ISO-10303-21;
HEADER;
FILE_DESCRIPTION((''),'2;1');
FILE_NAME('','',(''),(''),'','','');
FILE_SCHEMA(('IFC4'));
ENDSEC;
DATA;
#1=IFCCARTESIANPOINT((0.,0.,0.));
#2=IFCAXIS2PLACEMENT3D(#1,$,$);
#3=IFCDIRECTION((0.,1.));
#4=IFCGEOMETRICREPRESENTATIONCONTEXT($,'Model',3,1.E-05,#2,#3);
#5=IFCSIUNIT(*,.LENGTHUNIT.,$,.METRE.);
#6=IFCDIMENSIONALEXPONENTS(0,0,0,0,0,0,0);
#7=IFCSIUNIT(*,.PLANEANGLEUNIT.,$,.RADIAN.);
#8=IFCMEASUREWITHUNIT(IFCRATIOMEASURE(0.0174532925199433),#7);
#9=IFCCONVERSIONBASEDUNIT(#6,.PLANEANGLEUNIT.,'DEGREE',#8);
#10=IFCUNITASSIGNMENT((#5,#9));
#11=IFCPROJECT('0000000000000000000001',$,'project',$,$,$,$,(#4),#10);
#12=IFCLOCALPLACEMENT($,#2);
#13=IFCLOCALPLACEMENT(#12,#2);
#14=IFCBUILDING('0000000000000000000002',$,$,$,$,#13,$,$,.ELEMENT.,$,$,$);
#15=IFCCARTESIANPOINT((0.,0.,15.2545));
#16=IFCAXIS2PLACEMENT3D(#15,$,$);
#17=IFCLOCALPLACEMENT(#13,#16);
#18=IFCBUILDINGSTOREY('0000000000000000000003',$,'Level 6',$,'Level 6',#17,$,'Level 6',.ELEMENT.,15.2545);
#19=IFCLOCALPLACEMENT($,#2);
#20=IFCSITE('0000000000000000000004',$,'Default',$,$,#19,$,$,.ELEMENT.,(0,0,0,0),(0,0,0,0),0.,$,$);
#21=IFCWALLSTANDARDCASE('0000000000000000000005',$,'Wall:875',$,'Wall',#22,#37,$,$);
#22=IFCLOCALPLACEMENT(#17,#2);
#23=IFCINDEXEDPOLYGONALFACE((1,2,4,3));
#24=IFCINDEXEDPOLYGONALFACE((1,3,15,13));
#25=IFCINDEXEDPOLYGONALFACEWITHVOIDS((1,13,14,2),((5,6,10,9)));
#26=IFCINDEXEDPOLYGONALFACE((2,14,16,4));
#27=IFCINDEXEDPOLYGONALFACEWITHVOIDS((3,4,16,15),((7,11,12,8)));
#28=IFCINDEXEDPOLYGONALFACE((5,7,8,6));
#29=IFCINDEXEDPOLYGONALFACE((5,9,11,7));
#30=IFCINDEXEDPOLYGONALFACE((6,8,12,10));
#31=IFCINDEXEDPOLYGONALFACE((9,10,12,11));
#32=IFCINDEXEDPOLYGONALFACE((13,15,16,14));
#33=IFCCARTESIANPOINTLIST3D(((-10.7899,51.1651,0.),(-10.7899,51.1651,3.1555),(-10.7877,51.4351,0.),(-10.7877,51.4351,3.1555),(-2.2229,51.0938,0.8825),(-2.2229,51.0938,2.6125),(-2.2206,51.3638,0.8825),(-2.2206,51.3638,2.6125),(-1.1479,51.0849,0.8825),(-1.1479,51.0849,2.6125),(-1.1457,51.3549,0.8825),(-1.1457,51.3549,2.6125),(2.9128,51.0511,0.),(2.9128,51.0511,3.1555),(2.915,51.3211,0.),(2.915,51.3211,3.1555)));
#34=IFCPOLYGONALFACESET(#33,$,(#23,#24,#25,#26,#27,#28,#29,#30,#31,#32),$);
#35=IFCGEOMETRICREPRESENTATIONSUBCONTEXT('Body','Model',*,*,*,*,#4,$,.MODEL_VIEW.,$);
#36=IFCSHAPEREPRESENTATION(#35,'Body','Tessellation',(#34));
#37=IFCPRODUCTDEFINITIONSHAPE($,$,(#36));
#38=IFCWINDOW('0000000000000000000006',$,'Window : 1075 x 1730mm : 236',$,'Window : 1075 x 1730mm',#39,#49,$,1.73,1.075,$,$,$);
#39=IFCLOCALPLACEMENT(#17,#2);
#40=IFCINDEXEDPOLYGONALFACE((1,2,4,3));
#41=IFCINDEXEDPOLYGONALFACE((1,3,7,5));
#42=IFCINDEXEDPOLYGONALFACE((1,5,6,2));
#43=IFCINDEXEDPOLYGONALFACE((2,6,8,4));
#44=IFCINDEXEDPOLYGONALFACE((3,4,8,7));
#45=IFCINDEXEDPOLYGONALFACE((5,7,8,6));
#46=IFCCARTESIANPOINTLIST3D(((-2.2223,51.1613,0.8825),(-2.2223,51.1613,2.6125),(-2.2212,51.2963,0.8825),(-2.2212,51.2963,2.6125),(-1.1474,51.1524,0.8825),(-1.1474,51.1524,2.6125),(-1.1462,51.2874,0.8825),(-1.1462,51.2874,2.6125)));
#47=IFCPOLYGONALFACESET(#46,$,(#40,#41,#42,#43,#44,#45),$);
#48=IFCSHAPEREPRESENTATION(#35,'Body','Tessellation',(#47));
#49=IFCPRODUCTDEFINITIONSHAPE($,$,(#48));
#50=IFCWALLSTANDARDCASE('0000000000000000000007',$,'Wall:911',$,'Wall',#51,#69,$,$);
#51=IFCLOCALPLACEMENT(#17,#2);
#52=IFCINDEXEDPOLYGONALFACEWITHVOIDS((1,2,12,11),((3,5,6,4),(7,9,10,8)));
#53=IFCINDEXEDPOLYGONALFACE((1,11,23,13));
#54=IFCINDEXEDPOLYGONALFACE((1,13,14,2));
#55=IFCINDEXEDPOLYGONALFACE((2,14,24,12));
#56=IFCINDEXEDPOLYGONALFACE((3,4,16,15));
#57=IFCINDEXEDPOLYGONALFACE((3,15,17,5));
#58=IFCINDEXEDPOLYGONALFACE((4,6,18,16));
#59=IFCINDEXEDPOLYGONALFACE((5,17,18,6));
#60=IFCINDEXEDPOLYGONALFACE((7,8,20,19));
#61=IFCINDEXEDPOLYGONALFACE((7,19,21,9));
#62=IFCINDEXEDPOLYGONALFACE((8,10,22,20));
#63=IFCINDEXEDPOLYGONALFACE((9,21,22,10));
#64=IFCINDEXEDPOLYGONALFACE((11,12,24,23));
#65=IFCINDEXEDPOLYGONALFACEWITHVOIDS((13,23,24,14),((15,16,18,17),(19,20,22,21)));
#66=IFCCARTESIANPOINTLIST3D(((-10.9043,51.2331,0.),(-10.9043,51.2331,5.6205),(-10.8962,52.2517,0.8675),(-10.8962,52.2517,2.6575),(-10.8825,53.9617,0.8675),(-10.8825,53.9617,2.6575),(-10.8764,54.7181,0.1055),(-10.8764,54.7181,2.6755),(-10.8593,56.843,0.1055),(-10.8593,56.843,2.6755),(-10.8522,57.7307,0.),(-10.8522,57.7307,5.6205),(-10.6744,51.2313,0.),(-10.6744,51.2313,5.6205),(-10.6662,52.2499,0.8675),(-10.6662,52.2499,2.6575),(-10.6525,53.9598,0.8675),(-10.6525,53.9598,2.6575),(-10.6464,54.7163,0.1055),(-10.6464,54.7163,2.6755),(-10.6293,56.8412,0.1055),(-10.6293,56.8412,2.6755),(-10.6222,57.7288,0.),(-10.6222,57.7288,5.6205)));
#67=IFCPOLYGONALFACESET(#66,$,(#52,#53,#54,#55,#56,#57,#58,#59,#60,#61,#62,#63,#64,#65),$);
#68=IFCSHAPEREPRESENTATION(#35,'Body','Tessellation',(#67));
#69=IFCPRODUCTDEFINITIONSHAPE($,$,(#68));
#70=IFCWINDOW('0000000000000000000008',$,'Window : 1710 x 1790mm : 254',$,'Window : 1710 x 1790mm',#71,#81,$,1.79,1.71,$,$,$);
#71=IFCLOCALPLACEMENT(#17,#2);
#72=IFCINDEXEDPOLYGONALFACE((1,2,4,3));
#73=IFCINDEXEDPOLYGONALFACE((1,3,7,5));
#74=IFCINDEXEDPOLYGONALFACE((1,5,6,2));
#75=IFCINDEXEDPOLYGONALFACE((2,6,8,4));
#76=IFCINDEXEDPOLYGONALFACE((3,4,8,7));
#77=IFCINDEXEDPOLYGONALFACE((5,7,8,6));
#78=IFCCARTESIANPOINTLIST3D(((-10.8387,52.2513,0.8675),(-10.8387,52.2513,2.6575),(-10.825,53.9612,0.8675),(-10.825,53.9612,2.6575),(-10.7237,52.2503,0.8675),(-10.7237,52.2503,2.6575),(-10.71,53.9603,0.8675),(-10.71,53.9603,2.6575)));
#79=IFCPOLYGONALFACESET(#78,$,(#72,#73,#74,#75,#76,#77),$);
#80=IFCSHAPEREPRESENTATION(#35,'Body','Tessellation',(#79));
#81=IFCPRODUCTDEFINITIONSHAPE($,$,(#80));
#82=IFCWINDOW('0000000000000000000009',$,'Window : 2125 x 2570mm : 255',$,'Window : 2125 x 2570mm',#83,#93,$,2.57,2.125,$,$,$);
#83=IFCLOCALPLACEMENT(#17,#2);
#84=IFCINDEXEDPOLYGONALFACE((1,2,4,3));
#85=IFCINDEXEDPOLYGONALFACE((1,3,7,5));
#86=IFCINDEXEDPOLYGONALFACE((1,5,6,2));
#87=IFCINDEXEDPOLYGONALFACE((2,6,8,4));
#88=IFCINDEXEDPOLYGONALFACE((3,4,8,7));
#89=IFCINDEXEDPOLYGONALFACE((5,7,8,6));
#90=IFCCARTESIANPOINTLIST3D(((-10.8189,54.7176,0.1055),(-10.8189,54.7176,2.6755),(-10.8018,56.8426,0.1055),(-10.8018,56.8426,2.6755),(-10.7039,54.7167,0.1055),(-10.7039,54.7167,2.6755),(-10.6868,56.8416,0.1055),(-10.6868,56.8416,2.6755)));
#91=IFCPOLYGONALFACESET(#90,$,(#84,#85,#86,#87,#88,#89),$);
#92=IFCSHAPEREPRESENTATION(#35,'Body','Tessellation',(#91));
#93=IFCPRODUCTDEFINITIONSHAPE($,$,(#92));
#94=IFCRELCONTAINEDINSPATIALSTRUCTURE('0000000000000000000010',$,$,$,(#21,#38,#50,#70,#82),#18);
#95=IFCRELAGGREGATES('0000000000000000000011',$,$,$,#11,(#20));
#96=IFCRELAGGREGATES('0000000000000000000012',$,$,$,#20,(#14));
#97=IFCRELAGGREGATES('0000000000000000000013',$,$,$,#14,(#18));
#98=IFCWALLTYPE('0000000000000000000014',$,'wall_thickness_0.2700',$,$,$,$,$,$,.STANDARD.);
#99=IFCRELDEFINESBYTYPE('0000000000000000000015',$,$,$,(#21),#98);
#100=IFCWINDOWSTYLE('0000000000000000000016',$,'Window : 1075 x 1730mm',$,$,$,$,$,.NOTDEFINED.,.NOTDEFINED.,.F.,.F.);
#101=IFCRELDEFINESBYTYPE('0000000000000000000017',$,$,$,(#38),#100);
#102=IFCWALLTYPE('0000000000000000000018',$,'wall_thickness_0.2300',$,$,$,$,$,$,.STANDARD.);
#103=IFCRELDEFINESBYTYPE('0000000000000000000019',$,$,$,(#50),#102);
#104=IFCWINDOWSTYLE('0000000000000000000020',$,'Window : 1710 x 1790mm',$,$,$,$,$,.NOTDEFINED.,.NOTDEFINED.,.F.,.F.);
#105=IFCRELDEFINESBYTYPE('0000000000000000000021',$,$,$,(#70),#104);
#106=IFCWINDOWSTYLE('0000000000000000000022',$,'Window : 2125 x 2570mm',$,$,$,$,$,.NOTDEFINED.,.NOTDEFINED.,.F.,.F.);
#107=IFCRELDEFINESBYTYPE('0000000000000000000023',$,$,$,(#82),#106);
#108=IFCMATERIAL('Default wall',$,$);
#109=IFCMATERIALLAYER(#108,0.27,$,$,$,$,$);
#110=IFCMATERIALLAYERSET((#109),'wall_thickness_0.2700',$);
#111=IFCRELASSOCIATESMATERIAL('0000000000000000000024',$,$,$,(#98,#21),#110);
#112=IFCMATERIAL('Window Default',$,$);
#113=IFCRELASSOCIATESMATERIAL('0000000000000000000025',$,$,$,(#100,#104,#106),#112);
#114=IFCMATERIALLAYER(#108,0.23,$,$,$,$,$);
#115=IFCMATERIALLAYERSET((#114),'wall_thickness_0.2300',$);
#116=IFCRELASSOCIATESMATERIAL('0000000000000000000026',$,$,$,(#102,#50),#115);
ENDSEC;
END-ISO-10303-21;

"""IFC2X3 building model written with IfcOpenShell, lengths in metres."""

from ifc_helpers import new_model, entity, si_unit, converted_unit, direction, frame, frame_2d, origin, origin_2d_with_axis, place, context, subcontext, project, spatial, polyline, rectangle, outline, extrude, source, transform, mapped, material, layer, layer_set, layer_usage, type_object, type_shapes, element, fill, save


model = new_model("IFC2X3")

# Units and contexts
model_context = context("Model", 3, precision=1e-05, world=origin(), true_north=direction((0.0, 1.0)))
body_context = subcontext(model_context, "Body", "Model", "MODEL_VIEW")
ifc_project = project(units=[si_unit("LENGTHUNIT", "METRE"), converted_unit("PLANEANGLEUNIT", "DEGREE", entity("IfcRatioMeasure", 0.0174532925199433), si_unit("PLANEANGLEUNIT", "RADIAN"), dimensions=[0, 0, 0, 0, 0, 0, 0])], contexts=[model_context])

# Site, building, storey
site_placement = place(None, origin())
site = spatial("IfcSite", under=ifc_project, at=site_placement, Name="Default", CompositionType="ELEMENT", RefLatitude=(0, 0, 0, 0), RefLongitude=(0, 0, 0, 0), RefElevation=0.0)
placement = place(None, origin())
building_placement = place(placement, origin())
building = spatial("IfcBuilding", under=site, at=building_placement, CompositionType="ELEMENT")
storey_placement = place(building_placement, frame((0.0, 0.0, 15.2545)))
storey = spatial("IfcBuildingStorey", under=building, at=storey_placement, Name="Level 6", ObjectType="Level 6", LongName="Level 6", CompositionType="ELEMENT", Elevation=15.2545)

# Shared definitions
ifc_material_1 = material(Name="Default wall")

# Shared definitions
ifc_material_2 = material(Name="Window Default")

# Wall, opening, window
ifc_layer_1 = layer(ifc_material_1, 0.27)
ifc_layer_set_1 = layer_set([ifc_layer_1], Name="wall_thickness_0.2700")
ifc_layer_usage_1 = layer_usage(ifc_layer_set_1, "AXIS2", "POSITIVE", -0.135)
wall_type_1 = type_object("IfcWallType", Name="wall_thickness_0.2700", PredefinedType="STANDARD", material=ifc_layer_set_1)
wall_1_placement = place(storey_placement, frame((-10.7888, 51.3001, 0.0), z_axis=(0.0, 0.0, 1.0), x_axis=(0.999965, -0.008323, 0.0)))
wall_1 = element("IfcWallStandardCase", 1, at=wall_1_placement, inside=storey, type_object=wall_type_1, material=ifc_layer_usage_1, Name="Wall:875", ObjectType="Wall", context=body_context, shape_type="SweptSolid", body=[
    extrude(outline(polyline([(13.7032, -0.135), (13.7032, 0.135), (0.0, 0.135), (0.0, -0.135), (13.7032, -0.135)])), origin(), (0.0, 0.0, 1.0), 3.1555),
])
opening_1_placement = place(wall_1_placement, frame((8.5673, -0.135, 0.8825)))
opening_1 = element("IfcOpeningElement", 2, at=opening_1_placement, cuts=wall_1, ObjectType="Opening", context=body_context, shape_type="SweptSolid", body=[
    extrude(rectangle(XDim=1.075, YDim=1.73, at=frame_2d((0.865, 0.5375), x_axis=(0.0, 1.0))), frame((0.0, 0.0, 0.0), z_axis=(0.0, 1.0, 0.0), x_axis=(0.0, 0.0, 1.0)), (0.0, 0.0, 1.0), 0.27),
])
window_style_1 = type_object("IfcWindowStyle", Name="Window : 1075 x 1730mm", ConstructionType="NOTDEFINED", OperationType="NOTDEFINED", ParameterTakesPrecedence=False, Sizeable=False, material=ifc_material_2)
shared_shape_1 = source(origin(), body_context, "Body", "SweptSolid", [
    extrude(rectangle(XDim=0.135, YDim=1.075, at=origin_2d_with_axis()), frame((0.5375, 0.135, 0.0), z_axis=(0.0, 0.0, 1.0), x_axis=(0.0, 1.0, 0.0)), (0.0, 0.0, 1.0), 1.73),
])
type_shapes(window_style_1, [shared_shape_1])
window_1_placement = place(opening_1_placement, origin())
window_1 = element("IfcWindow", 3, at=window_1_placement, inside=storey, type_object=window_style_1, Name="Window : 1075 x 1730mm : 236", ObjectType="Window : 1075 x 1730mm", OverallHeight=1.73, OverallWidth=1.075, context=body_context, shape_type="MappedRepresentation", body=[
    mapped(shared_shape_1, transform((0.0, 0.0, 0.0), scale=1.0)),
])
fill(opening_1, window_1)

# Wall, openings, windows
ifc_layer_2 = layer(ifc_material_1, 0.23)
ifc_layer_set_2 = layer_set([ifc_layer_2], Name="wall_thickness_0.2300")
ifc_layer_usage_2 = layer_usage(ifc_layer_set_2, "AXIS2", "POSITIVE", -0.115)
wall_type_2 = type_object("IfcWallType", Name="wall_thickness_0.2300", PredefinedType="STANDARD", material=ifc_layer_set_2)
wall_2_placement = place(storey_placement, frame((-10.7372, 57.7298, 0.0), z_axis=(0.0, 0.0, 1.0), x_axis=(-0.008022, -0.999968, 0.0)))
wall_2 = element("IfcWallStandardCase", 4, at=wall_2_placement, inside=storey, type_object=wall_type_2, material=ifc_layer_usage_2, Name="Wall:911", ObjectType="Wall", context=body_context, shape_type="SweptSolid", body=[
    extrude(outline(polyline([(6.4978, -0.115), (6.4978, 0.115), (0.0, 0.115), (0.0, -0.115), (6.4978, -0.115)])), origin(), (0.0, 0.0, 1.0), 5.6205),
])
opening_2_placement = place(wall_2_placement, frame((3.7691, -0.115, 0.8675)))
opening_2 = element("IfcOpeningElement", 5, at=opening_2_placement, cuts=wall_2, ObjectType="Opening", context=body_context, shape_type="SweptSolid", body=[
    extrude(rectangle(XDim=1.71, YDim=1.79, at=frame_2d((0.895, 0.855), x_axis=(0.0, 1.0))), frame((0.0, 0.0, 0.0), z_axis=(0.0, 1.0, 0.0), x_axis=(0.0, 0.0, 1.0)), (0.0, 0.0, 1.0), 0.23),
])
opening_3_placement = place(wall_2_placement, frame((0.8877, -0.115, 0.1055)))
opening_3 = element("IfcOpeningElement", 6, at=opening_3_placement, cuts=wall_2, ObjectType="Opening", context=body_context, shape_type="SweptSolid", body=[
    extrude(rectangle(XDim=2.125, YDim=2.57, at=frame_2d((1.285, 1.0625), x_axis=(0.0, 1.0))), frame((0.0, 0.0, 0.0), z_axis=(0.0, 1.0, 0.0), x_axis=(0.0, 0.0, 1.0)), (0.0, 0.0, 1.0), 0.23),
])
window_style_2 = type_object("IfcWindowStyle", Name="Window : 1710 x 1790mm", ConstructionType="NOTDEFINED", OperationType="NOTDEFINED", ParameterTakesPrecedence=False, Sizeable=False, material=ifc_material_2)
shared_shape_2 = source(origin(), body_context, "Body", "SweptSolid", [
    extrude(rectangle(XDim=0.115, YDim=1.71, at=origin_2d_with_axis()), frame((0.855, 0.115, 0.0), z_axis=(0.0, 0.0, 1.0), x_axis=(0.0, 1.0, 0.0)), (0.0, 0.0, 1.0), 1.79),
])
type_shapes(window_style_2, [shared_shape_2])
window_2_placement = place(opening_2_placement, origin())
window_2 = element("IfcWindow", 7, at=window_2_placement, inside=storey, type_object=window_style_2, Name="Window : 1710 x 1790mm : 254", ObjectType="Window : 1710 x 1790mm", OverallHeight=1.79, OverallWidth=1.71, context=body_context, shape_type="MappedRepresentation", body=[
    mapped(shared_shape_2, transform((0.0, 0.0, 0.0), scale=1.0)),
])
fill(opening_2, window_2)
window_style_3 = type_object("IfcWindowStyle", Name="Window : 2125 x 2570mm", ConstructionType="NOTDEFINED", OperationType="NOTDEFINED", ParameterTakesPrecedence=False, Sizeable=False, material=ifc_material_2)
shared_shape_3 = source(origin(), body_context, "Body", "SweptSolid", [
    extrude(rectangle(XDim=0.115, YDim=2.125, at=origin_2d_with_axis()), frame((1.0625, 0.115, 0.0), z_axis=(0.0, 0.0, 1.0), x_axis=(0.0, 1.0, 0.0)), (0.0, 0.0, 1.0), 2.57),
])
type_shapes(window_style_3, [shared_shape_3])
window_3_placement = place(opening_3_placement, origin())
window_3 = element("IfcWindow", 8, at=window_3_placement, inside=storey, type_object=window_style_3, Name="Window : 2125 x 2570mm : 255", ObjectType="Window : 2125 x 2570mm", OverallHeight=2.57, OverallWidth=2.125, context=body_context, shape_type="MappedRepresentation", body=[
    mapped(shared_shape_3, transform((0.0, 0.0, 0.0), scale=1.0)),
])
fill(opening_3, window_3)

save(model, "model.ifc")
